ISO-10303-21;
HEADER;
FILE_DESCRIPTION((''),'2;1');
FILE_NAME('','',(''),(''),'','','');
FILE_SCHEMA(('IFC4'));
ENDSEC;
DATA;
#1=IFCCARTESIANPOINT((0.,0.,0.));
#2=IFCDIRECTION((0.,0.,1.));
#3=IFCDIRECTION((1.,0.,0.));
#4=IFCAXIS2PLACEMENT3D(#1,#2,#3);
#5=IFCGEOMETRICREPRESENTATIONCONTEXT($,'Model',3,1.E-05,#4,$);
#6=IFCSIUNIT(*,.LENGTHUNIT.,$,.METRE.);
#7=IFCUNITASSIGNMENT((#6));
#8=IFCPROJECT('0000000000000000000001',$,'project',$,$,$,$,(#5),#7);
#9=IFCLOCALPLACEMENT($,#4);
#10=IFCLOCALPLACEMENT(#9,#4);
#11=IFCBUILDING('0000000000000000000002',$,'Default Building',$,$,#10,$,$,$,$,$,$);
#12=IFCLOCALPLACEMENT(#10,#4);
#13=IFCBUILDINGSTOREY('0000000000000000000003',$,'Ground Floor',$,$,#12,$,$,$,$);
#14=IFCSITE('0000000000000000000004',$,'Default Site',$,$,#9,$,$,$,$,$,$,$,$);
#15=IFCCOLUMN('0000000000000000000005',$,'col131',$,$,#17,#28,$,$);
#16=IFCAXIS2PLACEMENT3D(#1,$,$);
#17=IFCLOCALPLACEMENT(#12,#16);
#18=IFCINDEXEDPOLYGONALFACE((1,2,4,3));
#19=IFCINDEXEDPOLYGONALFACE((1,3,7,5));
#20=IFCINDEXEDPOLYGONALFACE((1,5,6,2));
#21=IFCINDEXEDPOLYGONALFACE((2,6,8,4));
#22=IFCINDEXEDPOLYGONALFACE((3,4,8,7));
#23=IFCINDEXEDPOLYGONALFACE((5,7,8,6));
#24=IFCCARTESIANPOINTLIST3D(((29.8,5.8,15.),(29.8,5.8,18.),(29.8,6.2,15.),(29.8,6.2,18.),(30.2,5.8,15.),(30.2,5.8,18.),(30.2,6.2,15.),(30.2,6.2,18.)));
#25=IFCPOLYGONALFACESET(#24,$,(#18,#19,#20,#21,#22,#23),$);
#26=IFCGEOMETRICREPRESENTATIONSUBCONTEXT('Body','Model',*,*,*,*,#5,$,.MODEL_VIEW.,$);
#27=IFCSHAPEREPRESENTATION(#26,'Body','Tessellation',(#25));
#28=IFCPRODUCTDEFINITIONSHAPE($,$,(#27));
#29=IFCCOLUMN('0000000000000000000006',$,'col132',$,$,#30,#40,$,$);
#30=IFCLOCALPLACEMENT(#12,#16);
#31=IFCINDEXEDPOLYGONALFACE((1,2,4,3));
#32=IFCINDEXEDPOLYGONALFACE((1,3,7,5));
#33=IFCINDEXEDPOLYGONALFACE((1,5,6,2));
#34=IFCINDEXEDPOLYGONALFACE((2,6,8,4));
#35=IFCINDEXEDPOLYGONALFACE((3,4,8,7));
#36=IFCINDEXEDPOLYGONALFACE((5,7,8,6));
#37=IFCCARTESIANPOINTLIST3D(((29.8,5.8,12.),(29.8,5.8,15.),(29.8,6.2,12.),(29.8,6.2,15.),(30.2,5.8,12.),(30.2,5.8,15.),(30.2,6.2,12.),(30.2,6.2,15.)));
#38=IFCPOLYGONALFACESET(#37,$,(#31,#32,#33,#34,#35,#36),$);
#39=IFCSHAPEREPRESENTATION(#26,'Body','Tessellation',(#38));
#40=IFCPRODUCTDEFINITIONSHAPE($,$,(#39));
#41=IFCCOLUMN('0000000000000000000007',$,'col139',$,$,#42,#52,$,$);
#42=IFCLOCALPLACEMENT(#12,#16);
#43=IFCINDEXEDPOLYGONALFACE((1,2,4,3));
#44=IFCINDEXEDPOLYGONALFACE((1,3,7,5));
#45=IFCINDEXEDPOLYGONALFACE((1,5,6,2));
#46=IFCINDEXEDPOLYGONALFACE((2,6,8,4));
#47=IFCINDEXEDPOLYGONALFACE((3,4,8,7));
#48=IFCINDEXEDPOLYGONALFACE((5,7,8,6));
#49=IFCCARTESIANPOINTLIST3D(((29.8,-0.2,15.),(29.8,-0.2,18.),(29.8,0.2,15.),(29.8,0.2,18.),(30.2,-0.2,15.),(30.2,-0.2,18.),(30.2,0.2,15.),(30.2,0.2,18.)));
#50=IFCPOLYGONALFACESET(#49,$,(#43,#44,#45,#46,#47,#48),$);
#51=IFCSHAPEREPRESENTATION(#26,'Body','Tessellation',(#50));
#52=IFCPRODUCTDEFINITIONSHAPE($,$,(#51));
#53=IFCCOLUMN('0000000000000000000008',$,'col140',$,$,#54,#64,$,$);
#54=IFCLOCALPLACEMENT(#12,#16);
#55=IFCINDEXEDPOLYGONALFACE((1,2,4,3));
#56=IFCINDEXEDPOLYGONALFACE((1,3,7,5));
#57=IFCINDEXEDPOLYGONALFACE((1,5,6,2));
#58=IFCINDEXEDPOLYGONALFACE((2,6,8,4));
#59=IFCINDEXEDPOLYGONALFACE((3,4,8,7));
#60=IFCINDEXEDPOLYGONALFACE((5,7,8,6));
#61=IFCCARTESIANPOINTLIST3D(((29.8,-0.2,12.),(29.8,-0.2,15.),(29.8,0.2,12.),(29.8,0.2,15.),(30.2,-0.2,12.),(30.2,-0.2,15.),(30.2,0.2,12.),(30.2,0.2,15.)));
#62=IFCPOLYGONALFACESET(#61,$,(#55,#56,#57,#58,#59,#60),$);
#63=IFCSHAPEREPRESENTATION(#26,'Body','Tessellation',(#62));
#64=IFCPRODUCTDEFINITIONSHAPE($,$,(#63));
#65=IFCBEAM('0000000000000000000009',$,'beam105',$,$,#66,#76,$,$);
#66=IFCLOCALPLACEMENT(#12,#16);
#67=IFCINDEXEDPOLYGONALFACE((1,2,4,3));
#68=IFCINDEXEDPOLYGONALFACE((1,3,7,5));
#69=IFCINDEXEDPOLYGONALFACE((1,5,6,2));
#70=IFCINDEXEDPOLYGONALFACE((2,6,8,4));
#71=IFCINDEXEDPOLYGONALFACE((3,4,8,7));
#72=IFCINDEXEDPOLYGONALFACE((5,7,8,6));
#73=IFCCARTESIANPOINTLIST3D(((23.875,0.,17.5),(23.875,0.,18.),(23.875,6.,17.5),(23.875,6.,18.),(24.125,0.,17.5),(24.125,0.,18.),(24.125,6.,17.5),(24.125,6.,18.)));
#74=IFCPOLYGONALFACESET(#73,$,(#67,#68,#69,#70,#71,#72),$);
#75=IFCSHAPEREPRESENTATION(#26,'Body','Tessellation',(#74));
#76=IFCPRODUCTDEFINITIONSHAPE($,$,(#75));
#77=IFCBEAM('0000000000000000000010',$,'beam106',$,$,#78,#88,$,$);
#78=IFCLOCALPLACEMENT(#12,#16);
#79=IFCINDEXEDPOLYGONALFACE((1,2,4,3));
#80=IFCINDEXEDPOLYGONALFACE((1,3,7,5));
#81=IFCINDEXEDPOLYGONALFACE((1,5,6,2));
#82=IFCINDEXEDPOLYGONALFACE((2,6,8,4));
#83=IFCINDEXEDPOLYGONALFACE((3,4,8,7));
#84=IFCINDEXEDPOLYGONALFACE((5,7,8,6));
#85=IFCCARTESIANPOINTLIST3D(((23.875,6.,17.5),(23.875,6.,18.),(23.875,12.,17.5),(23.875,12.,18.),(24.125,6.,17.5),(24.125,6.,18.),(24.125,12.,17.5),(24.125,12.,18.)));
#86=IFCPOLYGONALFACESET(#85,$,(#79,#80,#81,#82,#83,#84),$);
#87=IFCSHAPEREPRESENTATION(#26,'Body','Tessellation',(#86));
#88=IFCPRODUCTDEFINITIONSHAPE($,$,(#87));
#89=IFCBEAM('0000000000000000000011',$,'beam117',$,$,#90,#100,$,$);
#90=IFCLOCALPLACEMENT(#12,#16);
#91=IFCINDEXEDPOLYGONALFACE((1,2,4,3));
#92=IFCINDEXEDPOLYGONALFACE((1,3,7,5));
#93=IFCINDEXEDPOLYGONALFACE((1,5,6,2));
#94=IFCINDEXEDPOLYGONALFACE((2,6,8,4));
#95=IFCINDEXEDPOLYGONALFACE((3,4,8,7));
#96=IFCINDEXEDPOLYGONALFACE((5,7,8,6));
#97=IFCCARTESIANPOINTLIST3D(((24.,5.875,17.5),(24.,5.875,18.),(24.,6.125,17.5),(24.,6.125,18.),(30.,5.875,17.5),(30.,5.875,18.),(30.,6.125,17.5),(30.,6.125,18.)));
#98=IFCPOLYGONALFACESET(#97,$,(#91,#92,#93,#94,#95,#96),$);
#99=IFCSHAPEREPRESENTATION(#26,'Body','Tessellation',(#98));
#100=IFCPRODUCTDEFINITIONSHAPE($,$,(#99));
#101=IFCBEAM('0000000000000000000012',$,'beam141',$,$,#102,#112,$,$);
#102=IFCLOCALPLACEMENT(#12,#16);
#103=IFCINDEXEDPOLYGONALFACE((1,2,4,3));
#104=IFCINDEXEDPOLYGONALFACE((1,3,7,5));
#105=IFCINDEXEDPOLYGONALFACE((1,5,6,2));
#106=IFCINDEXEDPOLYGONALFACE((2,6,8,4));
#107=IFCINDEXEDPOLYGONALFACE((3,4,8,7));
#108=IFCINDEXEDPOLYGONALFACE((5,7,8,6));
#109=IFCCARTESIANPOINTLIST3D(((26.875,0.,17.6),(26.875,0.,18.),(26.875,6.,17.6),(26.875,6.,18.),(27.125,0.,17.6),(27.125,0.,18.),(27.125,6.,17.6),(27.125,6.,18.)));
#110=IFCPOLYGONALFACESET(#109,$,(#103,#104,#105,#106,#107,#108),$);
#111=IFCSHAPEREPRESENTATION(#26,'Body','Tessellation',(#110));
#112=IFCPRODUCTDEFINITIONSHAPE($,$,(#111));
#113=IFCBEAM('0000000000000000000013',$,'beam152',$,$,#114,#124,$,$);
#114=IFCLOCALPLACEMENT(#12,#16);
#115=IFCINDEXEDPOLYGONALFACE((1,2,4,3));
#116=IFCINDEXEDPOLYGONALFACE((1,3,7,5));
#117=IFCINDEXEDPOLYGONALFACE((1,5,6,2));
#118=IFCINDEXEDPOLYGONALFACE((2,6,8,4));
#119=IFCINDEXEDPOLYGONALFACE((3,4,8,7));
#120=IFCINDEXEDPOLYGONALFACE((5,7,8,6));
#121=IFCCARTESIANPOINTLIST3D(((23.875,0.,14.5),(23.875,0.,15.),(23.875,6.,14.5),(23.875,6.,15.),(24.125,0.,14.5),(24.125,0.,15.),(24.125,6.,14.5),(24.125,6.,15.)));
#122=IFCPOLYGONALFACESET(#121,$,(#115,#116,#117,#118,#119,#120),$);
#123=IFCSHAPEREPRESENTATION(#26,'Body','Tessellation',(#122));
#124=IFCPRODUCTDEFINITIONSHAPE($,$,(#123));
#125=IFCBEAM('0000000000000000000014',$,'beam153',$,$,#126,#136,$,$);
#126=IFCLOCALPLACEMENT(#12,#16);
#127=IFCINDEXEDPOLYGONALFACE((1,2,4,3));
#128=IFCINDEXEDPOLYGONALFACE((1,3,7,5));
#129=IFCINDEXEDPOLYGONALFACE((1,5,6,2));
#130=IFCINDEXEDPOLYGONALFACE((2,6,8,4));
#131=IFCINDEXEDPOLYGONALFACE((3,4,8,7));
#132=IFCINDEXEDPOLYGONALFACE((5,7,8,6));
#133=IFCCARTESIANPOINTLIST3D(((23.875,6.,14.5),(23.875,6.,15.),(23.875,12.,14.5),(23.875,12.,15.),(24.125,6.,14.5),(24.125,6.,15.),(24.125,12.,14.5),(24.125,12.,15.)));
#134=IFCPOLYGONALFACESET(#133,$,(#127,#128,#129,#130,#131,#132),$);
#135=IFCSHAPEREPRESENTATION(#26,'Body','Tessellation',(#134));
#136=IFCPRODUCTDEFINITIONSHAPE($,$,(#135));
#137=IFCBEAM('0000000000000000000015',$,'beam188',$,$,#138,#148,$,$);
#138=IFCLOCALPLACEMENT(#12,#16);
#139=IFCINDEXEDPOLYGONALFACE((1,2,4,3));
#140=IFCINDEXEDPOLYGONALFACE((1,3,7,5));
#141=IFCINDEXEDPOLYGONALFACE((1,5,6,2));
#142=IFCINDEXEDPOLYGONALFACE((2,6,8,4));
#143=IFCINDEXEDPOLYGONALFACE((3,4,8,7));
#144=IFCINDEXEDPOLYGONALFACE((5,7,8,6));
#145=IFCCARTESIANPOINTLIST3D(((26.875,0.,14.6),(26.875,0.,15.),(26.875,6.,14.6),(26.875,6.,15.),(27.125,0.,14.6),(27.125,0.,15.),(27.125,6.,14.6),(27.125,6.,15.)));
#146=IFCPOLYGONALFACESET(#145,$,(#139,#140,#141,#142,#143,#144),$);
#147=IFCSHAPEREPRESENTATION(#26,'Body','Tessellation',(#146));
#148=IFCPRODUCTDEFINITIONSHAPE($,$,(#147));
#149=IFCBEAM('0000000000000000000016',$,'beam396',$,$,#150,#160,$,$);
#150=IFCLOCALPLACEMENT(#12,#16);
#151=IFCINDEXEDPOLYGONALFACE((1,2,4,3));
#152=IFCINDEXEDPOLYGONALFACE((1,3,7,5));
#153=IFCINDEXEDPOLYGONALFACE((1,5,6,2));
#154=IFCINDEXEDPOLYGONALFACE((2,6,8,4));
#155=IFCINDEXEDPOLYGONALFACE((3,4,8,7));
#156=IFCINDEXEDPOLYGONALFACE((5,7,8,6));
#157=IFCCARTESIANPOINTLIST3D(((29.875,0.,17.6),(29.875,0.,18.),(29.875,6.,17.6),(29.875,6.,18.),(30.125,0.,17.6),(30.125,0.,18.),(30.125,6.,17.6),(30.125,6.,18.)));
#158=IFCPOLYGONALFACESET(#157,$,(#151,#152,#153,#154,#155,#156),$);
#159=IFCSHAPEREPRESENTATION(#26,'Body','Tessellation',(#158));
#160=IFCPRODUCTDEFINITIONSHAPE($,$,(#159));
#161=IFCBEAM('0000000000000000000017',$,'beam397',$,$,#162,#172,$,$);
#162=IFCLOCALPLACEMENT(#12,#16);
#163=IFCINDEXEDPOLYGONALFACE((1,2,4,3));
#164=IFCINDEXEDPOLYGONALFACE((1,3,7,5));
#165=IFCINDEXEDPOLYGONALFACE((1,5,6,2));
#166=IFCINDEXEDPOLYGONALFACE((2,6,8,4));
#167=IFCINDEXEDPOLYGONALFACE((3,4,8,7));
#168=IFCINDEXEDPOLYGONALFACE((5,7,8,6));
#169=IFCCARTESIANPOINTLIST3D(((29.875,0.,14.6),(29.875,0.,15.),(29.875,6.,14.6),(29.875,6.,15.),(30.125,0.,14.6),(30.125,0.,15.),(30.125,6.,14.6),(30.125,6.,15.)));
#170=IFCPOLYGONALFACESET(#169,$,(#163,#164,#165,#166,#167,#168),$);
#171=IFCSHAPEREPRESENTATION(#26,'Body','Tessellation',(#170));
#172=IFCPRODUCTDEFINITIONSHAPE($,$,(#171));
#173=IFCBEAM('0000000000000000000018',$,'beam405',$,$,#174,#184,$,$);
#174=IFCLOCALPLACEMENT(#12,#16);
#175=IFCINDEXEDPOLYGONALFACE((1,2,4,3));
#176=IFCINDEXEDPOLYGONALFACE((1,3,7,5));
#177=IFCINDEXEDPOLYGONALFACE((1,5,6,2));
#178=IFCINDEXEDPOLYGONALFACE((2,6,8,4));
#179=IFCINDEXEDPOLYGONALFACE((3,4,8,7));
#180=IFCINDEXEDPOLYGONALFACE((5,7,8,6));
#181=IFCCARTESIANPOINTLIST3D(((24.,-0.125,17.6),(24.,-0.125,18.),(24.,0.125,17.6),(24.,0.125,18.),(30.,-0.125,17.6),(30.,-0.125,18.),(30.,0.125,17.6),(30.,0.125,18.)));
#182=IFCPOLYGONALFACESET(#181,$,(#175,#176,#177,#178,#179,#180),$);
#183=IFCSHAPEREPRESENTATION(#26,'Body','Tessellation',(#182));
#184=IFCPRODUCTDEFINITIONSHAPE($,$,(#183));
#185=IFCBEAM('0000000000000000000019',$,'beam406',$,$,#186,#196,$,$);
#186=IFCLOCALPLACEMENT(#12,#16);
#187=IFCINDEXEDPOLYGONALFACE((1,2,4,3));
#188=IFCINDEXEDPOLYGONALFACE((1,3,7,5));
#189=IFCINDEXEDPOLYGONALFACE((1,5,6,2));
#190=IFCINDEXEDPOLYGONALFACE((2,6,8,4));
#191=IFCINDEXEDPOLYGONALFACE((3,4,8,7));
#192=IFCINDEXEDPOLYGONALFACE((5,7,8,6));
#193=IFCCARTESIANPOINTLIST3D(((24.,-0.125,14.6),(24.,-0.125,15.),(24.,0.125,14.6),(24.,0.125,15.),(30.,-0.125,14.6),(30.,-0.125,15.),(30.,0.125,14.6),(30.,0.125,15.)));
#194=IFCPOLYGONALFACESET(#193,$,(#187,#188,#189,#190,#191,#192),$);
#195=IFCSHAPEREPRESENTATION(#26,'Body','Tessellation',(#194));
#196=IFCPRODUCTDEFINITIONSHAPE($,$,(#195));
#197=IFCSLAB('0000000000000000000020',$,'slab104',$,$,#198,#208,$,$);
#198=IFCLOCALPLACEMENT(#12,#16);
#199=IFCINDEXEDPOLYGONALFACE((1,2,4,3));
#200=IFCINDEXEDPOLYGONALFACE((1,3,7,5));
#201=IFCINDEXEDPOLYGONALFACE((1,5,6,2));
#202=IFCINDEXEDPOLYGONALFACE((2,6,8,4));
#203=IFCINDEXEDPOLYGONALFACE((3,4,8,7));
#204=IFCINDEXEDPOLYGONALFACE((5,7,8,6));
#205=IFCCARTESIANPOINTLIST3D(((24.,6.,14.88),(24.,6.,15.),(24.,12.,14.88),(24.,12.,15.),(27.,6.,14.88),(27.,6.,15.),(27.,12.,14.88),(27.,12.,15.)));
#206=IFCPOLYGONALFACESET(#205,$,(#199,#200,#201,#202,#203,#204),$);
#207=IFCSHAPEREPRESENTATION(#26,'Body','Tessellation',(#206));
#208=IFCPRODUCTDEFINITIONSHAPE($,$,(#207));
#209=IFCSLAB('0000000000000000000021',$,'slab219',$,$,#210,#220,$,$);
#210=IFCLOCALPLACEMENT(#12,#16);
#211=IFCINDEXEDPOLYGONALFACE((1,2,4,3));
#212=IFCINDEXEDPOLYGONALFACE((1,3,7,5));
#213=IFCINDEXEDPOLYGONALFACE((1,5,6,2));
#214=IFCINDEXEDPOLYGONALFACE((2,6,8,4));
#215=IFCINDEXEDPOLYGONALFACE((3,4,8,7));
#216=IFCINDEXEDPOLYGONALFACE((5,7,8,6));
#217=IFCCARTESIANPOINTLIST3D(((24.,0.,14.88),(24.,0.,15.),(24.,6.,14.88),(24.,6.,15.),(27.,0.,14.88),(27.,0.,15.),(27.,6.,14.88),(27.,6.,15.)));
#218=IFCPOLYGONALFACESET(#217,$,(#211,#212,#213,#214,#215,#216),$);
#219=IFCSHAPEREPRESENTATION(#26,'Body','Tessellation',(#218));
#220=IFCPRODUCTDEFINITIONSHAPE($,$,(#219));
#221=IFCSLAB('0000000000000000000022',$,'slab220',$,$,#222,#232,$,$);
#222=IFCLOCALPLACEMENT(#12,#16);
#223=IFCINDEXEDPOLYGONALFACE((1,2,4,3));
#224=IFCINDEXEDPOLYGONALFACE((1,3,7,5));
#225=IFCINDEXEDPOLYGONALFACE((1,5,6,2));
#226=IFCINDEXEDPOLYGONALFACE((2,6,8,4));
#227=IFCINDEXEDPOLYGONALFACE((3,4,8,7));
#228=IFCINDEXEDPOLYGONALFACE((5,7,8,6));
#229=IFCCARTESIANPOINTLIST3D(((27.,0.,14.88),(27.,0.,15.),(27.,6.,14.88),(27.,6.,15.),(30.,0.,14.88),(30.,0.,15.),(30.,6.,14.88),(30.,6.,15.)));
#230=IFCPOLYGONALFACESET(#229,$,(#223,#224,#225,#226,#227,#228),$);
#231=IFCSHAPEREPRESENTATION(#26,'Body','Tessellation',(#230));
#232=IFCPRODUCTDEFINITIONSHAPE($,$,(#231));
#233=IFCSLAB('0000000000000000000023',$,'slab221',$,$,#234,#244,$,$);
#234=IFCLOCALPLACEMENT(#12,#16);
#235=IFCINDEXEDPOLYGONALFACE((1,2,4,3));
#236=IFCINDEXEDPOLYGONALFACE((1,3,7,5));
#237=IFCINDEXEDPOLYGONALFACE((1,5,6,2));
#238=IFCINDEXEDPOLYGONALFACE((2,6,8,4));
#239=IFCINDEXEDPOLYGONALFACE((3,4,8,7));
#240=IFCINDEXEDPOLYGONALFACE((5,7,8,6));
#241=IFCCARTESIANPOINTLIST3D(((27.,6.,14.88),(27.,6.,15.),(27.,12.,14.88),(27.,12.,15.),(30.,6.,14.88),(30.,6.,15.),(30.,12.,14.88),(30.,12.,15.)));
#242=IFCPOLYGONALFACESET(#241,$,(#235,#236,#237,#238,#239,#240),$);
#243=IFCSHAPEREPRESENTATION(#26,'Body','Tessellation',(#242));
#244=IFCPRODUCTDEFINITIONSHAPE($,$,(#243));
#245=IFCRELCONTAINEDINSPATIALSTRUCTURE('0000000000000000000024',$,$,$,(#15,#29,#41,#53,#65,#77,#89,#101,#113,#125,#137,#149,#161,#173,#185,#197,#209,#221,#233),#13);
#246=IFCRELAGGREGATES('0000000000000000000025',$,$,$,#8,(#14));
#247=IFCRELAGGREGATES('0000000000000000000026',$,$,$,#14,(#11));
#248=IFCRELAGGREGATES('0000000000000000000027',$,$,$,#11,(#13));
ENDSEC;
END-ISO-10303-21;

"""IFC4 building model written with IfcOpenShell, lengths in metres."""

from ifc_helpers import new_model, si_unit, frame, origin_with_axes, place, context, subcontext, project, spatial, indexed_curve, outline, extrude, element, save


model = new_model("IFC4")

# Units and contexts
model_context = context("Model", 3, precision=1e-05, world=origin_with_axes())
body_context = subcontext(model_context, "Body", "Model", "MODEL_VIEW")
ifc_project = project(units=[si_unit("LENGTHUNIT", "METRE")], contexts=[model_context])

# Site, building, storey
site_placement = place(None, origin_with_axes())
site = spatial("IfcSite", under=ifc_project, at=site_placement, Name="Default Site")
building_placement = place(site_placement, origin_with_axes())
building = spatial("IfcBuilding", under=site, at=building_placement, Name="Default Building")
storey_placement = place(building_placement, origin_with_axes())
storey = spatial("IfcBuildingStorey", under=building, at=storey_placement, Name="Ground Floor")

# Columns
for number, where, z_axis, x_axis, name in (
    (1, (29.8, 5.8, 15.0), (0.0, 0.0, 1.0), (1.0, 0.0, 0.0), "col131"),
    (2, (29.8, 5.8, 12.0), (0.0, 0.0, 1.0), (1.0, 0.0, 0.0), "col132"),
    (3, (29.8, -0.2, 15.0), (0.0, 0.0, 1.0), (1.0, 0.0, 0.0), "col139"),
    (4, (29.8, -0.2, 12.0), (0.0, 0.0, 1.0), (1.0, 0.0, 0.0), "col140"),
):
    element("IfcColumn", number, at=place(storey_placement, frame(where, z_axis=z_axis, x_axis=x_axis)), inside=storey, Name=name, context=body_context, shape_type="SweptSolid", body=[
        extrude(outline(indexed_curve([(0.0, 0.0), (0.0, 0.4), (0.4, 0.4), (0.4, 0.0), (0.0, 0.0)], self_intersect=False)), origin_with_axes(), (0.0, 0.0, 1.0), 3.0),
    ])

# Beams
for number, where, z_axis, x_axis, name in (
    (5, (24.125, 0.0, 17.5), (0.0, 0.0, 1.0), (0.0, 1.0, 0.0), "beam105"),
    (6, (24.125, 6.0, 17.5), (0.0, 0.0, 1.0), (0.0, 1.0, 0.0), "beam106"),
    (7, (24.0, 5.875, 17.5), (0.0, 0.0, 1.0), (1.0, 0.0, 0.0), "beam117"),
):
    element("IfcBeam", number, at=place(storey_placement, frame(where, z_axis=z_axis, x_axis=x_axis)), inside=storey, Name=name, context=body_context, shape_type="SweptSolid", body=[
        extrude(outline(indexed_curve([(0.0, 0.0), (0.0, 0.25), (6.0, 0.25), (6.0, 0.0), (0.0, 0.0)], self_intersect=False)), origin_with_axes(), (0.0, 0.0, 1.0), 0.5),
    ])
beam_placement = place(storey_placement, frame((26.875, 6.0, 17.6), z_axis=(0.0, 0.0, 1.0), x_axis=(0.0, -1.0, 0.0)))
element("IfcBeam", 8, at=beam_placement, inside=storey, Name="beam141", context=body_context, shape_type="SweptSolid", body=[
    extrude(outline(indexed_curve([(0.0, 0.0), (0.0, 0.25), (6.0, 0.25), (6.0, 0.0), (0.0, 0.0)], self_intersect=False)), origin_with_axes(), (0.0, 0.0, 1.0), 0.4),
])
for number, where, z_axis, x_axis, name in (
    (9, (24.125, 0.0, 14.5), (0.0, 0.0, 1.0), (0.0, 1.0, 0.0), "beam152"),
    (10, (24.125, 6.0, 14.5), (0.0, 0.0, 1.0), (0.0, 1.0, 0.0), "beam153"),
):
    element("IfcBeam", number, at=place(storey_placement, frame(where, z_axis=z_axis, x_axis=x_axis)), inside=storey, Name=name, context=body_context, shape_type="SweptSolid", body=[
        extrude(outline(indexed_curve([(0.0, 0.0), (0.0, 0.25), (6.0, 0.25), (6.0, 0.0), (0.0, 0.0)], self_intersect=False)), origin_with_axes(), (0.0, 0.0, 1.0), 0.5),
    ])
for number, where, z_axis, x_axis, name in (
    (11, (26.875, 6.0, 14.6), (0.0, 0.0, 1.0), (0.0, -1.0, 0.0), "beam188"),
    (12, (29.875, 6.0, 17.6), (0.0, 0.0, 1.0), (0.0, -1.0, 0.0), "beam396"),
    (13, (29.875, 6.0, 14.6), (0.0, 0.0, 1.0), (0.0, -1.0, 0.0), "beam397"),
    (14, (24.0, -0.125, 17.6), (0.0, 0.0, 1.0), (1.0, 0.0, 0.0), "beam405"),
    (15, (24.0, -0.125, 14.6), (0.0, 0.0, 1.0), (1.0, 0.0, 0.0), "beam406"),
):
    element("IfcBeam", number, at=place(storey_placement, frame(where, z_axis=z_axis, x_axis=x_axis)), inside=storey, Name=name, context=body_context, shape_type="SweptSolid", body=[
        extrude(outline(indexed_curve([(0.0, 0.0), (0.0, 0.25), (6.0, 0.25), (6.0, 0.0), (0.0, 0.0)], self_intersect=False)), origin_with_axes(), (0.0, 0.0, 1.0), 0.4),
    ])

# Slabs
for number, where, z_axis, x_axis, name in (
    (16, (24.0, 6.0, 14.88), (0.0, 0.0, 1.0), (1.0, 0.0, 0.0), "slab104"),
    (17, (24.0, 0.0, 14.88), (0.0, 0.0, 1.0), (1.0, 0.0, 0.0), "slab219"),
    (18, (27.0, 0.0, 14.88), (0.0, 0.0, 1.0), (1.0, 0.0, 0.0), "slab220"),
    (19, (27.0, 6.0, 14.88), (0.0, 0.0, 1.0), (1.0, 0.0, 0.0), "slab221"),
):
    element("IfcSlab", number, at=place(storey_placement, frame(where, z_axis=z_axis, x_axis=x_axis)), inside=storey, Name=name, context=body_context, shape_type="SweptSolid", body=[
        extrude(outline(indexed_curve([(0.0, 0.0), (0.0, 6.0), (3.0, 6.0), (3.0, 0.0), (0.0, 0.0)], self_intersect=False)), origin_with_axes(), (0.0, 0.0, 1.0), 0.12),
    ])

save(model, "model.ifc")
